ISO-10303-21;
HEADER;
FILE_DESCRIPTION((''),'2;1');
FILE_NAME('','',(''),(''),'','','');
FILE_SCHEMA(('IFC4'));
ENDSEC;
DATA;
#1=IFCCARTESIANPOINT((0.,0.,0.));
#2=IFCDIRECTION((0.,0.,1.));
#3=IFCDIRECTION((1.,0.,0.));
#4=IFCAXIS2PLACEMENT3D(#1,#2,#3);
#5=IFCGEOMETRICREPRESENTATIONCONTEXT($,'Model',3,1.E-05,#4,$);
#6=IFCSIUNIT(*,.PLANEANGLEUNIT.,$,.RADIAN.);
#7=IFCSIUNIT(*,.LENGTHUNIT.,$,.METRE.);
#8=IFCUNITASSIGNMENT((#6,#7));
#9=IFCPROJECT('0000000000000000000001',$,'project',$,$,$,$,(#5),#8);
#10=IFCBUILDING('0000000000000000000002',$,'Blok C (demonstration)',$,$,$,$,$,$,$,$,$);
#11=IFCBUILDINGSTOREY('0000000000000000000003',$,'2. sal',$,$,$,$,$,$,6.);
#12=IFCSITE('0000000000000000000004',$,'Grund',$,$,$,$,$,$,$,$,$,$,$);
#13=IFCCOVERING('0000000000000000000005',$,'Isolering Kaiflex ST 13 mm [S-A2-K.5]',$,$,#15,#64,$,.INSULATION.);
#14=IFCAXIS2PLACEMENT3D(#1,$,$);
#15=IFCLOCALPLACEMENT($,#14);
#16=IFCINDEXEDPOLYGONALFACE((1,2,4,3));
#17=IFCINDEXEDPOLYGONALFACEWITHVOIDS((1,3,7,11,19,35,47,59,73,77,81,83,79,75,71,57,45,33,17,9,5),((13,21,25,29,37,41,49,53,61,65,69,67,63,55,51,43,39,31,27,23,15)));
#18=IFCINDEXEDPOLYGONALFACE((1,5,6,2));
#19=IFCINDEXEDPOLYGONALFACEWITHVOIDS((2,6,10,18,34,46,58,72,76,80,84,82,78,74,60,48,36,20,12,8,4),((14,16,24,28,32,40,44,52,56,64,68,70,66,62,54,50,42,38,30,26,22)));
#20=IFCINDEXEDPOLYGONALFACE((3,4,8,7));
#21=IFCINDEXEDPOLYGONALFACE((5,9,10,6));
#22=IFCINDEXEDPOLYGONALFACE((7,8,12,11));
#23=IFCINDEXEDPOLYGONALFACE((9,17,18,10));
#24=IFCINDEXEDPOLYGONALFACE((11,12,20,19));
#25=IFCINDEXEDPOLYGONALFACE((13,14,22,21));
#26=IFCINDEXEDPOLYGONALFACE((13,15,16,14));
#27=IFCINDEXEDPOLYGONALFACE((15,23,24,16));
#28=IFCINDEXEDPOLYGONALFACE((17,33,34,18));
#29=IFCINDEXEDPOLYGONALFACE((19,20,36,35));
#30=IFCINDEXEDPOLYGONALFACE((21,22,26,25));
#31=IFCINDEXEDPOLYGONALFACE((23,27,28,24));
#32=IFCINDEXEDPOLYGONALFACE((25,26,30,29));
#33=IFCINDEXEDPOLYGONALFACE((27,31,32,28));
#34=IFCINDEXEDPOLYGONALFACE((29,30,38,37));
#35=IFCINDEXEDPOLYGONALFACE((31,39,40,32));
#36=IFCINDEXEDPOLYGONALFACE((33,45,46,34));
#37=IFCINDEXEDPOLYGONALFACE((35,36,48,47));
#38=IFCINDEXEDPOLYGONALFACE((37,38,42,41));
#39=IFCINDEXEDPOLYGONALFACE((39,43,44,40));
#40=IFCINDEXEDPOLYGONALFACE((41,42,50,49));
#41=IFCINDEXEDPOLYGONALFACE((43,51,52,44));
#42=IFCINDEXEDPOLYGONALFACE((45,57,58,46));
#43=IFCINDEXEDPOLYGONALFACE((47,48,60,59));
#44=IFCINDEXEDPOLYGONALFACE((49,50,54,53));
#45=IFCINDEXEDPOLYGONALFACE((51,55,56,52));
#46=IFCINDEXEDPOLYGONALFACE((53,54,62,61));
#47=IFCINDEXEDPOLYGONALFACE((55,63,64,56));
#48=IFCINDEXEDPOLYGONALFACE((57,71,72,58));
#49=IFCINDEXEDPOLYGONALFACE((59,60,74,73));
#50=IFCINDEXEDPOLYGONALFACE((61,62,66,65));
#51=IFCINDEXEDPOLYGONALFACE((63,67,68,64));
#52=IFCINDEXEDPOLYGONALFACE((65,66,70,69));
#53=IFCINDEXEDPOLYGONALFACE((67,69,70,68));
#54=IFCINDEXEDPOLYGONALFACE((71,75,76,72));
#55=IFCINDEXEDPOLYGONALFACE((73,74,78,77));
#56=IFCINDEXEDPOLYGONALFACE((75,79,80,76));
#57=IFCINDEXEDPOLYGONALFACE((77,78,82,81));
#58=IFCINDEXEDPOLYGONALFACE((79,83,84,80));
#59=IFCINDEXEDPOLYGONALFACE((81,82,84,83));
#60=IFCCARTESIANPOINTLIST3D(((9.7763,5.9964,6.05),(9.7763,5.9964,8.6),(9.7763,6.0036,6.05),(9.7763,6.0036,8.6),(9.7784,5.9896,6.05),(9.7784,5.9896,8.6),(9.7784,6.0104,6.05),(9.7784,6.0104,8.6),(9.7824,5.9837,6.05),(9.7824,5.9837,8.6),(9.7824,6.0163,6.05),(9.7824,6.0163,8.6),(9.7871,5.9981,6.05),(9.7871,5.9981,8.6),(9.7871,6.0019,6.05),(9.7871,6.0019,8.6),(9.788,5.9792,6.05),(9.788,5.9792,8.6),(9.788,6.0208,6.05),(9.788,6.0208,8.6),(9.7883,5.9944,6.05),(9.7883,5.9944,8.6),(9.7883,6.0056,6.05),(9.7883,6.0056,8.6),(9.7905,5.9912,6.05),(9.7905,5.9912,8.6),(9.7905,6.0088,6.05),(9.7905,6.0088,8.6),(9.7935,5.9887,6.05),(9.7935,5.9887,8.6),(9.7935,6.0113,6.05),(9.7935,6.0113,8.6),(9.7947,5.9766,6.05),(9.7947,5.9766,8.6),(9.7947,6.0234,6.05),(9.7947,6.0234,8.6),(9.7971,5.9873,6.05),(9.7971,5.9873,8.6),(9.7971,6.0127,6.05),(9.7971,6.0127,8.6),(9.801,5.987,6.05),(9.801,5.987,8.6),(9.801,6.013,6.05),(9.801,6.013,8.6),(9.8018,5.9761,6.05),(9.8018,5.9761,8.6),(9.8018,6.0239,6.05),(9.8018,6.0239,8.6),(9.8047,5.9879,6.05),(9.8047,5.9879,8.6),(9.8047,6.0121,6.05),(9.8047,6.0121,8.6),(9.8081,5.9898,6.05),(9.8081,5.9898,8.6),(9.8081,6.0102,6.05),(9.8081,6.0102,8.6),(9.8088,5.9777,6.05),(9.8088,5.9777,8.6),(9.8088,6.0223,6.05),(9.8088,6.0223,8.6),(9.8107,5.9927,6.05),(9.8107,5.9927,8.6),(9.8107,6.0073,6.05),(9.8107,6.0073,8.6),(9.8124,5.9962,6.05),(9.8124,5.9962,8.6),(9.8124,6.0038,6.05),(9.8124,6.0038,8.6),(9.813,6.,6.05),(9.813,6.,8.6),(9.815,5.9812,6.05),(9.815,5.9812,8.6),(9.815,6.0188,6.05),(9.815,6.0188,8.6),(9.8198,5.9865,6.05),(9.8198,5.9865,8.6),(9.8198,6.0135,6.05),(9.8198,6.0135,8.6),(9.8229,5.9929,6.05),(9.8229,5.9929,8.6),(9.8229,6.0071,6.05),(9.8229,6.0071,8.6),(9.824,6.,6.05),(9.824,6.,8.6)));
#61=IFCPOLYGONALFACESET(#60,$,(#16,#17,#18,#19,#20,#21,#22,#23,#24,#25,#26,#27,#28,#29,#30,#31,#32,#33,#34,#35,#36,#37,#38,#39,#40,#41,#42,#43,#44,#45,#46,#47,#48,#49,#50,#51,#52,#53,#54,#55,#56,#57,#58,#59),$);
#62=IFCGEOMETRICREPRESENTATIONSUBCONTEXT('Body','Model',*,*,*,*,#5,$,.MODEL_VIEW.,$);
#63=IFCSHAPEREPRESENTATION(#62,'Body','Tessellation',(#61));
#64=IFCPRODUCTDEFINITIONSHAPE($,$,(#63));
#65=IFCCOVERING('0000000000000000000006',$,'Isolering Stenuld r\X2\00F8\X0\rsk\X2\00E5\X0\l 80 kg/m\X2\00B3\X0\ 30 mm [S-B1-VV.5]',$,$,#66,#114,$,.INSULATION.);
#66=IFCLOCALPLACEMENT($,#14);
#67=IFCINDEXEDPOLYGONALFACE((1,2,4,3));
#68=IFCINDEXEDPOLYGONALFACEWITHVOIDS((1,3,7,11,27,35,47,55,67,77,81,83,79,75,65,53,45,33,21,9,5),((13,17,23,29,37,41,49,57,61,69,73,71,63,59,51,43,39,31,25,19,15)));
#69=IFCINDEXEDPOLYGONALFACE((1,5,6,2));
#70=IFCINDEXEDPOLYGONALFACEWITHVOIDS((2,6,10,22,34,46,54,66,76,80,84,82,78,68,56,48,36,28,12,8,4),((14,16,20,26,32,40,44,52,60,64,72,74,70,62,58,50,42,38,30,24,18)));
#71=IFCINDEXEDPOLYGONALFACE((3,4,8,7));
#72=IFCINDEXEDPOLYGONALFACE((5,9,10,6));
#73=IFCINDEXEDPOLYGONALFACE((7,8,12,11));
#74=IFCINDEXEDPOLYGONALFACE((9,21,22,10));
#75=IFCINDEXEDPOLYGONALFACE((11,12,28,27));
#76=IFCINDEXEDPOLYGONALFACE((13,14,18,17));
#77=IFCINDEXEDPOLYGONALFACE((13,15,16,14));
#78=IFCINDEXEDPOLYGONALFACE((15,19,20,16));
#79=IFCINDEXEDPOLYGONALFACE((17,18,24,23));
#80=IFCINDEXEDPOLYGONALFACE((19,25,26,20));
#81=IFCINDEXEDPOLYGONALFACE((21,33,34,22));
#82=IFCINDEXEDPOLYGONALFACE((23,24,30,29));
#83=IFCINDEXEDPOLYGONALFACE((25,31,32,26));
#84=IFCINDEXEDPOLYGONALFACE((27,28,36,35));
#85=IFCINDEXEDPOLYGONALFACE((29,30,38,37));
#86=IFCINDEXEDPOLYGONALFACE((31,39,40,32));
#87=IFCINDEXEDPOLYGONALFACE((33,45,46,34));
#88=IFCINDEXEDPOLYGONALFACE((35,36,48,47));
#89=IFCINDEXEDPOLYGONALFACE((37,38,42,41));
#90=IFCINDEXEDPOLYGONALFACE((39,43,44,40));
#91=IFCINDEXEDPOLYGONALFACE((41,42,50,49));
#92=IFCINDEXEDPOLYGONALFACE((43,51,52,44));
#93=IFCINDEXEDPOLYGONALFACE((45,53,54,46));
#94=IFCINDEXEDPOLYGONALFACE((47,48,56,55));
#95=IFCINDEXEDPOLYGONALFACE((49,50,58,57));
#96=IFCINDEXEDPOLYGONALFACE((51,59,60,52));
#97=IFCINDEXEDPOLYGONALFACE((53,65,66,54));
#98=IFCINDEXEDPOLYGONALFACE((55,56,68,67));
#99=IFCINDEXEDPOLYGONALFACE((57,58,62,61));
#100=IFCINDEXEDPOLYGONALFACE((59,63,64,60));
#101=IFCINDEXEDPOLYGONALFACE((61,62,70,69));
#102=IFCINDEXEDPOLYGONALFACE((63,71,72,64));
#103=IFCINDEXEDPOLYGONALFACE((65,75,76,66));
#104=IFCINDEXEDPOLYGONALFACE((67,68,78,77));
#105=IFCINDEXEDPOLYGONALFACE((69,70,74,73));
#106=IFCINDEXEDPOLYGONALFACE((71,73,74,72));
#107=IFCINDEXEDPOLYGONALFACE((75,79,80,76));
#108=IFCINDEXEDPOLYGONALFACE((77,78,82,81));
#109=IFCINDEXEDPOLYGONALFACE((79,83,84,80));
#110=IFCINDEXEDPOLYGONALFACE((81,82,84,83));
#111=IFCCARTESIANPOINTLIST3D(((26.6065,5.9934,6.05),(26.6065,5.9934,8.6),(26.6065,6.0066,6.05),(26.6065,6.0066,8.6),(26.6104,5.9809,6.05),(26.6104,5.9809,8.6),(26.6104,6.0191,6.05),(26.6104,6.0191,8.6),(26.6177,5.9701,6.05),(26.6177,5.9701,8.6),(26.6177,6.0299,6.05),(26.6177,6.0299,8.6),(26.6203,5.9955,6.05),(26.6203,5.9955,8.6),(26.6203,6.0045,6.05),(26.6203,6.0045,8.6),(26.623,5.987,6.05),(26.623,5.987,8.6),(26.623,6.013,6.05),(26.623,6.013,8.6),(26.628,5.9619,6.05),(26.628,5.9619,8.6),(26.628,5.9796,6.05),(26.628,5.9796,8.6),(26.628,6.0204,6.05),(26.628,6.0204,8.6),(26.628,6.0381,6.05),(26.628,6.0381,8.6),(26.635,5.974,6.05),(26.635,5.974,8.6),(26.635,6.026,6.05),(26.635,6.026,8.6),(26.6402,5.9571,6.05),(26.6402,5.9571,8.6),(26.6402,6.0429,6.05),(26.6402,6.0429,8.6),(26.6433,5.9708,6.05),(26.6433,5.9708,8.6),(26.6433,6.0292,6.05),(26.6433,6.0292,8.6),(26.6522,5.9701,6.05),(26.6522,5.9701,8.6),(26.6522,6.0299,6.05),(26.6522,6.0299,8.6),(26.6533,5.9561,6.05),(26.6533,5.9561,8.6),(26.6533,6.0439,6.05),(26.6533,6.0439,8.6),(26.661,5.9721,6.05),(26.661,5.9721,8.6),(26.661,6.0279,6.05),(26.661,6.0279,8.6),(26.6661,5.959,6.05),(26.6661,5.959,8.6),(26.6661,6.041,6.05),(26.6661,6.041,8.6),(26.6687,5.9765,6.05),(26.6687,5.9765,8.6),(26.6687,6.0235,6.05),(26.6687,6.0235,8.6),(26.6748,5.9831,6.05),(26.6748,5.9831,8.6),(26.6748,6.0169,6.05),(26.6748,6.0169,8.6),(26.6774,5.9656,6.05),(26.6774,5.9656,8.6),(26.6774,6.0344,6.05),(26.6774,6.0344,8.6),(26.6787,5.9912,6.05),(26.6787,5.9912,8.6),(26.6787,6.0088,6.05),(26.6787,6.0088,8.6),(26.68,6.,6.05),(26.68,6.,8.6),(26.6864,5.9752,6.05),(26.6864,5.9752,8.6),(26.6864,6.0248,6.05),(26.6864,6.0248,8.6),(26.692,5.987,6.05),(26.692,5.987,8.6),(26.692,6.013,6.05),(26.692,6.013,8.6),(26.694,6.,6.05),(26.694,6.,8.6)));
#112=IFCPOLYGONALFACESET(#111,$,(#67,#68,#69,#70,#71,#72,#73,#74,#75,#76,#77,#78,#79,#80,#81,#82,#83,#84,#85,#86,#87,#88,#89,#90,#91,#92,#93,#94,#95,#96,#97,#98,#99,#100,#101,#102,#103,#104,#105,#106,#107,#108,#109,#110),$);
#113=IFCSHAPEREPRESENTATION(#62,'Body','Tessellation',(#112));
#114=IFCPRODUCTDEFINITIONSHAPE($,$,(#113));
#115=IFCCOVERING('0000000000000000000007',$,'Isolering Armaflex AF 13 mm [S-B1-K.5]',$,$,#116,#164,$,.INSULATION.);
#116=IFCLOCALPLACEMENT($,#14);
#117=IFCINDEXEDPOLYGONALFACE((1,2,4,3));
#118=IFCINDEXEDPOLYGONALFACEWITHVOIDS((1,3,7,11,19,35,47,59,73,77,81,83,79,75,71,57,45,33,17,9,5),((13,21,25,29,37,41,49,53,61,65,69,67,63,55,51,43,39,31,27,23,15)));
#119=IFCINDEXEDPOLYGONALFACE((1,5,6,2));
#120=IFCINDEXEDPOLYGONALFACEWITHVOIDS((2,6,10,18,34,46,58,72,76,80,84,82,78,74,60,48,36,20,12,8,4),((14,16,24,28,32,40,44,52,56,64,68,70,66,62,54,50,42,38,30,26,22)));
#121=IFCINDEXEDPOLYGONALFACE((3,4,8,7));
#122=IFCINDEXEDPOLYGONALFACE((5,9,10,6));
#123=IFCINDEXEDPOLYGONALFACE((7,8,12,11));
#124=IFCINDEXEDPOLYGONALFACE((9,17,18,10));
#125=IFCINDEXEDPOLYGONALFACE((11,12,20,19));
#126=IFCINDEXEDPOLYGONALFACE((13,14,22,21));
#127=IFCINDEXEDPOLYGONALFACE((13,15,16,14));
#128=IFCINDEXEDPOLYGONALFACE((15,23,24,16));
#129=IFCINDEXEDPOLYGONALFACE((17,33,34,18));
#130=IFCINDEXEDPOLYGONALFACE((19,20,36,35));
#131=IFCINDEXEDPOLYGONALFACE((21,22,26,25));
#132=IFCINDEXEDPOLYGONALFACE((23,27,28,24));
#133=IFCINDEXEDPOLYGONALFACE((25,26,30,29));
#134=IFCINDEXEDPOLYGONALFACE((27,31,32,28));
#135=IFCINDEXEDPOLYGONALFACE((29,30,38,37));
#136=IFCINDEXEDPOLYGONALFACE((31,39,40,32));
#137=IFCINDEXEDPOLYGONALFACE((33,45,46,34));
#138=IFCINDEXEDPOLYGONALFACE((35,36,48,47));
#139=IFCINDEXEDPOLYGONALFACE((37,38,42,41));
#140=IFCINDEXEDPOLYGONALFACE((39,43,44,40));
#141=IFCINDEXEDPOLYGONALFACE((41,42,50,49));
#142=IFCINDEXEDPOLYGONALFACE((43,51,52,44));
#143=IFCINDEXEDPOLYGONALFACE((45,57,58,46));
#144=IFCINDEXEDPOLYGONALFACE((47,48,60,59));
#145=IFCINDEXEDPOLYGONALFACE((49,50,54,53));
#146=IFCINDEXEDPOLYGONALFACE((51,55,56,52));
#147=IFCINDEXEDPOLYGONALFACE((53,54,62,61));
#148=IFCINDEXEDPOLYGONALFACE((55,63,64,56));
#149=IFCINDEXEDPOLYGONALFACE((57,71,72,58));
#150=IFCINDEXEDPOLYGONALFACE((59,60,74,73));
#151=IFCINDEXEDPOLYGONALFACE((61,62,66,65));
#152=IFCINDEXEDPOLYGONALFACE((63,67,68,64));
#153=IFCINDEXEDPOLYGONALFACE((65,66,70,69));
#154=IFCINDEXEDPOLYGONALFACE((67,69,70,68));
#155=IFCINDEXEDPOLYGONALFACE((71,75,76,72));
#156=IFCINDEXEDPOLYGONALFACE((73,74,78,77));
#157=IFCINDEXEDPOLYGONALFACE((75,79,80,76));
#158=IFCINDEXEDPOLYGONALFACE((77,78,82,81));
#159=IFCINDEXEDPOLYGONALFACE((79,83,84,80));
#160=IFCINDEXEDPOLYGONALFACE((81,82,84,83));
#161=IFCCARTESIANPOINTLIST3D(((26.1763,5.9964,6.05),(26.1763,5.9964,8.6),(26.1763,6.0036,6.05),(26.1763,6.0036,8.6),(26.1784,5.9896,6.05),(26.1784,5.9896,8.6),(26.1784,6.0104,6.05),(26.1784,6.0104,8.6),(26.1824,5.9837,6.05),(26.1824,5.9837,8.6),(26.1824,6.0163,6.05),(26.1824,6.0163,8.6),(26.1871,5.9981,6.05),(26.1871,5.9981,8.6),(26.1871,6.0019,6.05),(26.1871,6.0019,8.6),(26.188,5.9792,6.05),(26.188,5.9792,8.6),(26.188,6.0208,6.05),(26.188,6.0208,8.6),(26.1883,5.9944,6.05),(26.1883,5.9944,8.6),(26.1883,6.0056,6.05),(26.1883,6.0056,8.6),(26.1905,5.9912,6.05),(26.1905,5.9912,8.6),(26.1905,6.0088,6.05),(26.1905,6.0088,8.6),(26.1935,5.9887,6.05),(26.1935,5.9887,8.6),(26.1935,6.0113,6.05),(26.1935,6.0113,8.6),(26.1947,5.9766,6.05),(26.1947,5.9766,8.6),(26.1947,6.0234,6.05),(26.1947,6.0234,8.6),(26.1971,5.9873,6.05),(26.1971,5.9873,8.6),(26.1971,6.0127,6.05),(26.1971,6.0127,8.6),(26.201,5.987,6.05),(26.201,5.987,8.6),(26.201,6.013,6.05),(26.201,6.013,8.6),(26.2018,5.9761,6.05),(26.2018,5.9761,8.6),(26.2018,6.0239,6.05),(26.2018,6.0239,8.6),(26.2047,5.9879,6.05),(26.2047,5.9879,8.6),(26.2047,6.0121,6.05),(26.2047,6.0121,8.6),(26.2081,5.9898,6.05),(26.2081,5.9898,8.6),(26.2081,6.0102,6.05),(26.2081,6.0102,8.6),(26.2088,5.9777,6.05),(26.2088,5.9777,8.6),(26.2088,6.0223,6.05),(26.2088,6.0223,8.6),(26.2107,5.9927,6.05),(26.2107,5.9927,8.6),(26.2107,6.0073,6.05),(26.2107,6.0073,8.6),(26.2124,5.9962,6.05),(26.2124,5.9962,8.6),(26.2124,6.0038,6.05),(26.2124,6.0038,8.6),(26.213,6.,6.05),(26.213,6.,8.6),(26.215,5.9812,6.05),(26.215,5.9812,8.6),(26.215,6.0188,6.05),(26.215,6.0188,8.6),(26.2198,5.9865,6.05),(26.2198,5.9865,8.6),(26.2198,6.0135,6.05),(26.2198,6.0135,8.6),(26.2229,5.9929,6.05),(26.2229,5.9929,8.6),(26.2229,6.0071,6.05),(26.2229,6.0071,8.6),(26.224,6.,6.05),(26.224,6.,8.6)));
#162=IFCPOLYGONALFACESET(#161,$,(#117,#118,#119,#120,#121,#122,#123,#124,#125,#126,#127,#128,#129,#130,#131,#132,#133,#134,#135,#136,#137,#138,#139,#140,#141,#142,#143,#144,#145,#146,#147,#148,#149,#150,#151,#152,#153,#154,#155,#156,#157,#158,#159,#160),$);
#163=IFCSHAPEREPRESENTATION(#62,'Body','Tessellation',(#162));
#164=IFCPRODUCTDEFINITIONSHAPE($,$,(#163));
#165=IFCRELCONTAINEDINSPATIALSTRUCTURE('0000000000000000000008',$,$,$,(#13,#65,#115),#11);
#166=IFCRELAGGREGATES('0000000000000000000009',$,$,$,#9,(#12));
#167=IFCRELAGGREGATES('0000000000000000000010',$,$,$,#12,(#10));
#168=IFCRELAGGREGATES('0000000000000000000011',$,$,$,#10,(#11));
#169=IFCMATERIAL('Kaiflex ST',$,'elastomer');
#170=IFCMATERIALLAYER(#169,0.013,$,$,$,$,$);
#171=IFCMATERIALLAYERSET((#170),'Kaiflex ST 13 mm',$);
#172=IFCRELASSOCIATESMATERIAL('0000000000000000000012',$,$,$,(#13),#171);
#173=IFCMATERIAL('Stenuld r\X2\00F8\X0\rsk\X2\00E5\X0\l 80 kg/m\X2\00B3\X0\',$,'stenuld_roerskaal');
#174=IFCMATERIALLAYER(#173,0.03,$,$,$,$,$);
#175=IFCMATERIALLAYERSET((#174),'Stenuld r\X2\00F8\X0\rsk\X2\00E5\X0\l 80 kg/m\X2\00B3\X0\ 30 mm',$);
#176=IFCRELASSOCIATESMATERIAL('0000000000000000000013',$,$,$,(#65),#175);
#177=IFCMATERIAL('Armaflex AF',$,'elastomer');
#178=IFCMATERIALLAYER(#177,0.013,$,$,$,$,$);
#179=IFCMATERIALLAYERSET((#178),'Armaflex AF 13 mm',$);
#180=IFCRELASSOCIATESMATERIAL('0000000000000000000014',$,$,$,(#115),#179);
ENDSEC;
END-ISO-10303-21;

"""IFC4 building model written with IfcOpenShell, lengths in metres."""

from ifc_helpers import new_model, si_unit, frame, origin_with_axes, place, context, subcontext, project, spatial, hollow_circle, extrude, material, layer, layer_set, element, save


model = new_model("IFC4")

# Units and contexts
model_context = context("Model", 3, precision=1e-05, world=origin_with_axes())
body_context = subcontext(model_context, "Body", "Model", "MODEL_VIEW")
ifc_project = project(units=[si_unit("PLANEANGLEUNIT", "RADIAN"), si_unit("LENGTHUNIT", "METRE")], contexts=[model_context])

# Site, building, storey
site = spatial("IfcSite", under=ifc_project, Name="Grund")
building = spatial("IfcBuilding", under=site, Name="Blok C (demonstration)")
storey = spatial("IfcBuildingStorey", under=building, Name="2. sal", Elevation=6.0)

# Coverings
ifc_material_1 = material(Name="Stenuld rørskål 80 kg/m³", Category="stenuld_roerskaal")
ifc_material_2 = material(Name="Kaiflex ST", Category="elastomer")
ifc_layer_1 = layer(ifc_material_2, 0.013)
ifc_layer_set_1 = layer_set([ifc_layer_1], Name="Kaiflex ST 13 mm")
covering_1_placement = place(None, origin_with_axes())
element("IfcCovering", 1, at=covering_1_placement, inside=storey, material=ifc_layer_set_1, Name="Isolering Kaiflex ST 13 mm [S-A2-K.5]", PredefinedType="INSULATION", context=body_context, shape_type="SweptSolid", body=[
    extrude(hollow_circle(Radius=0.024, WallThickness=0.011), frame((9.8, 6.0, 6.05), z_axis=(0.0, 0.0, 1.0), x_axis=(1.0, 0.0, 0.0)), (0.0, 0.0, 1.0), 2.55),
])
ifc_layer_2 = layer(ifc_material_1, 0.03)
ifc_layer_set_2 = layer_set([ifc_layer_2], Name="Stenuld rørskål 80 kg/m³ 30 mm")
covering_2_placement = place(None, origin_with_axes())
element("IfcCovering", 2, at=covering_2_placement, inside=storey, material=ifc_layer_set_2, Name="Isolering Stenuld rørskål 80 kg/m³ 30 mm [S-B1-VV.5]", PredefinedType="INSULATION", context=body_context, shape_type="SweptSolid", body=[
    extrude(hollow_circle(Radius=0.044, WallThickness=0.014), frame((26.65, 6.0, 6.05), z_axis=(0.0, 0.0, 1.0), x_axis=(1.0, 0.0, 0.0)), (0.0, 0.0, 1.0), 2.55),
])
ifc_material_3 = material(Name="Armaflex AF", Category="elastomer")
ifc_layer_3 = layer(ifc_material_3, 0.013)
ifc_layer_set_3 = layer_set([ifc_layer_3], Name="Armaflex AF 13 mm")
covering_3_placement = place(None, origin_with_axes())
element("IfcCovering", 3, at=covering_3_placement, inside=storey, material=ifc_layer_set_3, Name="Isolering Armaflex AF 13 mm [S-B1-K.5]", PredefinedType="INSULATION", context=body_context, shape_type="SweptSolid", body=[
    extrude(hollow_circle(Radius=0.024, WallThickness=0.011), frame((26.2, 6.0, 6.05), z_axis=(0.0, 0.0, 1.0), x_axis=(1.0, 0.0, 0.0)), (0.0, 0.0, 1.0), 2.55),
])

save(model, "model.ifc")
